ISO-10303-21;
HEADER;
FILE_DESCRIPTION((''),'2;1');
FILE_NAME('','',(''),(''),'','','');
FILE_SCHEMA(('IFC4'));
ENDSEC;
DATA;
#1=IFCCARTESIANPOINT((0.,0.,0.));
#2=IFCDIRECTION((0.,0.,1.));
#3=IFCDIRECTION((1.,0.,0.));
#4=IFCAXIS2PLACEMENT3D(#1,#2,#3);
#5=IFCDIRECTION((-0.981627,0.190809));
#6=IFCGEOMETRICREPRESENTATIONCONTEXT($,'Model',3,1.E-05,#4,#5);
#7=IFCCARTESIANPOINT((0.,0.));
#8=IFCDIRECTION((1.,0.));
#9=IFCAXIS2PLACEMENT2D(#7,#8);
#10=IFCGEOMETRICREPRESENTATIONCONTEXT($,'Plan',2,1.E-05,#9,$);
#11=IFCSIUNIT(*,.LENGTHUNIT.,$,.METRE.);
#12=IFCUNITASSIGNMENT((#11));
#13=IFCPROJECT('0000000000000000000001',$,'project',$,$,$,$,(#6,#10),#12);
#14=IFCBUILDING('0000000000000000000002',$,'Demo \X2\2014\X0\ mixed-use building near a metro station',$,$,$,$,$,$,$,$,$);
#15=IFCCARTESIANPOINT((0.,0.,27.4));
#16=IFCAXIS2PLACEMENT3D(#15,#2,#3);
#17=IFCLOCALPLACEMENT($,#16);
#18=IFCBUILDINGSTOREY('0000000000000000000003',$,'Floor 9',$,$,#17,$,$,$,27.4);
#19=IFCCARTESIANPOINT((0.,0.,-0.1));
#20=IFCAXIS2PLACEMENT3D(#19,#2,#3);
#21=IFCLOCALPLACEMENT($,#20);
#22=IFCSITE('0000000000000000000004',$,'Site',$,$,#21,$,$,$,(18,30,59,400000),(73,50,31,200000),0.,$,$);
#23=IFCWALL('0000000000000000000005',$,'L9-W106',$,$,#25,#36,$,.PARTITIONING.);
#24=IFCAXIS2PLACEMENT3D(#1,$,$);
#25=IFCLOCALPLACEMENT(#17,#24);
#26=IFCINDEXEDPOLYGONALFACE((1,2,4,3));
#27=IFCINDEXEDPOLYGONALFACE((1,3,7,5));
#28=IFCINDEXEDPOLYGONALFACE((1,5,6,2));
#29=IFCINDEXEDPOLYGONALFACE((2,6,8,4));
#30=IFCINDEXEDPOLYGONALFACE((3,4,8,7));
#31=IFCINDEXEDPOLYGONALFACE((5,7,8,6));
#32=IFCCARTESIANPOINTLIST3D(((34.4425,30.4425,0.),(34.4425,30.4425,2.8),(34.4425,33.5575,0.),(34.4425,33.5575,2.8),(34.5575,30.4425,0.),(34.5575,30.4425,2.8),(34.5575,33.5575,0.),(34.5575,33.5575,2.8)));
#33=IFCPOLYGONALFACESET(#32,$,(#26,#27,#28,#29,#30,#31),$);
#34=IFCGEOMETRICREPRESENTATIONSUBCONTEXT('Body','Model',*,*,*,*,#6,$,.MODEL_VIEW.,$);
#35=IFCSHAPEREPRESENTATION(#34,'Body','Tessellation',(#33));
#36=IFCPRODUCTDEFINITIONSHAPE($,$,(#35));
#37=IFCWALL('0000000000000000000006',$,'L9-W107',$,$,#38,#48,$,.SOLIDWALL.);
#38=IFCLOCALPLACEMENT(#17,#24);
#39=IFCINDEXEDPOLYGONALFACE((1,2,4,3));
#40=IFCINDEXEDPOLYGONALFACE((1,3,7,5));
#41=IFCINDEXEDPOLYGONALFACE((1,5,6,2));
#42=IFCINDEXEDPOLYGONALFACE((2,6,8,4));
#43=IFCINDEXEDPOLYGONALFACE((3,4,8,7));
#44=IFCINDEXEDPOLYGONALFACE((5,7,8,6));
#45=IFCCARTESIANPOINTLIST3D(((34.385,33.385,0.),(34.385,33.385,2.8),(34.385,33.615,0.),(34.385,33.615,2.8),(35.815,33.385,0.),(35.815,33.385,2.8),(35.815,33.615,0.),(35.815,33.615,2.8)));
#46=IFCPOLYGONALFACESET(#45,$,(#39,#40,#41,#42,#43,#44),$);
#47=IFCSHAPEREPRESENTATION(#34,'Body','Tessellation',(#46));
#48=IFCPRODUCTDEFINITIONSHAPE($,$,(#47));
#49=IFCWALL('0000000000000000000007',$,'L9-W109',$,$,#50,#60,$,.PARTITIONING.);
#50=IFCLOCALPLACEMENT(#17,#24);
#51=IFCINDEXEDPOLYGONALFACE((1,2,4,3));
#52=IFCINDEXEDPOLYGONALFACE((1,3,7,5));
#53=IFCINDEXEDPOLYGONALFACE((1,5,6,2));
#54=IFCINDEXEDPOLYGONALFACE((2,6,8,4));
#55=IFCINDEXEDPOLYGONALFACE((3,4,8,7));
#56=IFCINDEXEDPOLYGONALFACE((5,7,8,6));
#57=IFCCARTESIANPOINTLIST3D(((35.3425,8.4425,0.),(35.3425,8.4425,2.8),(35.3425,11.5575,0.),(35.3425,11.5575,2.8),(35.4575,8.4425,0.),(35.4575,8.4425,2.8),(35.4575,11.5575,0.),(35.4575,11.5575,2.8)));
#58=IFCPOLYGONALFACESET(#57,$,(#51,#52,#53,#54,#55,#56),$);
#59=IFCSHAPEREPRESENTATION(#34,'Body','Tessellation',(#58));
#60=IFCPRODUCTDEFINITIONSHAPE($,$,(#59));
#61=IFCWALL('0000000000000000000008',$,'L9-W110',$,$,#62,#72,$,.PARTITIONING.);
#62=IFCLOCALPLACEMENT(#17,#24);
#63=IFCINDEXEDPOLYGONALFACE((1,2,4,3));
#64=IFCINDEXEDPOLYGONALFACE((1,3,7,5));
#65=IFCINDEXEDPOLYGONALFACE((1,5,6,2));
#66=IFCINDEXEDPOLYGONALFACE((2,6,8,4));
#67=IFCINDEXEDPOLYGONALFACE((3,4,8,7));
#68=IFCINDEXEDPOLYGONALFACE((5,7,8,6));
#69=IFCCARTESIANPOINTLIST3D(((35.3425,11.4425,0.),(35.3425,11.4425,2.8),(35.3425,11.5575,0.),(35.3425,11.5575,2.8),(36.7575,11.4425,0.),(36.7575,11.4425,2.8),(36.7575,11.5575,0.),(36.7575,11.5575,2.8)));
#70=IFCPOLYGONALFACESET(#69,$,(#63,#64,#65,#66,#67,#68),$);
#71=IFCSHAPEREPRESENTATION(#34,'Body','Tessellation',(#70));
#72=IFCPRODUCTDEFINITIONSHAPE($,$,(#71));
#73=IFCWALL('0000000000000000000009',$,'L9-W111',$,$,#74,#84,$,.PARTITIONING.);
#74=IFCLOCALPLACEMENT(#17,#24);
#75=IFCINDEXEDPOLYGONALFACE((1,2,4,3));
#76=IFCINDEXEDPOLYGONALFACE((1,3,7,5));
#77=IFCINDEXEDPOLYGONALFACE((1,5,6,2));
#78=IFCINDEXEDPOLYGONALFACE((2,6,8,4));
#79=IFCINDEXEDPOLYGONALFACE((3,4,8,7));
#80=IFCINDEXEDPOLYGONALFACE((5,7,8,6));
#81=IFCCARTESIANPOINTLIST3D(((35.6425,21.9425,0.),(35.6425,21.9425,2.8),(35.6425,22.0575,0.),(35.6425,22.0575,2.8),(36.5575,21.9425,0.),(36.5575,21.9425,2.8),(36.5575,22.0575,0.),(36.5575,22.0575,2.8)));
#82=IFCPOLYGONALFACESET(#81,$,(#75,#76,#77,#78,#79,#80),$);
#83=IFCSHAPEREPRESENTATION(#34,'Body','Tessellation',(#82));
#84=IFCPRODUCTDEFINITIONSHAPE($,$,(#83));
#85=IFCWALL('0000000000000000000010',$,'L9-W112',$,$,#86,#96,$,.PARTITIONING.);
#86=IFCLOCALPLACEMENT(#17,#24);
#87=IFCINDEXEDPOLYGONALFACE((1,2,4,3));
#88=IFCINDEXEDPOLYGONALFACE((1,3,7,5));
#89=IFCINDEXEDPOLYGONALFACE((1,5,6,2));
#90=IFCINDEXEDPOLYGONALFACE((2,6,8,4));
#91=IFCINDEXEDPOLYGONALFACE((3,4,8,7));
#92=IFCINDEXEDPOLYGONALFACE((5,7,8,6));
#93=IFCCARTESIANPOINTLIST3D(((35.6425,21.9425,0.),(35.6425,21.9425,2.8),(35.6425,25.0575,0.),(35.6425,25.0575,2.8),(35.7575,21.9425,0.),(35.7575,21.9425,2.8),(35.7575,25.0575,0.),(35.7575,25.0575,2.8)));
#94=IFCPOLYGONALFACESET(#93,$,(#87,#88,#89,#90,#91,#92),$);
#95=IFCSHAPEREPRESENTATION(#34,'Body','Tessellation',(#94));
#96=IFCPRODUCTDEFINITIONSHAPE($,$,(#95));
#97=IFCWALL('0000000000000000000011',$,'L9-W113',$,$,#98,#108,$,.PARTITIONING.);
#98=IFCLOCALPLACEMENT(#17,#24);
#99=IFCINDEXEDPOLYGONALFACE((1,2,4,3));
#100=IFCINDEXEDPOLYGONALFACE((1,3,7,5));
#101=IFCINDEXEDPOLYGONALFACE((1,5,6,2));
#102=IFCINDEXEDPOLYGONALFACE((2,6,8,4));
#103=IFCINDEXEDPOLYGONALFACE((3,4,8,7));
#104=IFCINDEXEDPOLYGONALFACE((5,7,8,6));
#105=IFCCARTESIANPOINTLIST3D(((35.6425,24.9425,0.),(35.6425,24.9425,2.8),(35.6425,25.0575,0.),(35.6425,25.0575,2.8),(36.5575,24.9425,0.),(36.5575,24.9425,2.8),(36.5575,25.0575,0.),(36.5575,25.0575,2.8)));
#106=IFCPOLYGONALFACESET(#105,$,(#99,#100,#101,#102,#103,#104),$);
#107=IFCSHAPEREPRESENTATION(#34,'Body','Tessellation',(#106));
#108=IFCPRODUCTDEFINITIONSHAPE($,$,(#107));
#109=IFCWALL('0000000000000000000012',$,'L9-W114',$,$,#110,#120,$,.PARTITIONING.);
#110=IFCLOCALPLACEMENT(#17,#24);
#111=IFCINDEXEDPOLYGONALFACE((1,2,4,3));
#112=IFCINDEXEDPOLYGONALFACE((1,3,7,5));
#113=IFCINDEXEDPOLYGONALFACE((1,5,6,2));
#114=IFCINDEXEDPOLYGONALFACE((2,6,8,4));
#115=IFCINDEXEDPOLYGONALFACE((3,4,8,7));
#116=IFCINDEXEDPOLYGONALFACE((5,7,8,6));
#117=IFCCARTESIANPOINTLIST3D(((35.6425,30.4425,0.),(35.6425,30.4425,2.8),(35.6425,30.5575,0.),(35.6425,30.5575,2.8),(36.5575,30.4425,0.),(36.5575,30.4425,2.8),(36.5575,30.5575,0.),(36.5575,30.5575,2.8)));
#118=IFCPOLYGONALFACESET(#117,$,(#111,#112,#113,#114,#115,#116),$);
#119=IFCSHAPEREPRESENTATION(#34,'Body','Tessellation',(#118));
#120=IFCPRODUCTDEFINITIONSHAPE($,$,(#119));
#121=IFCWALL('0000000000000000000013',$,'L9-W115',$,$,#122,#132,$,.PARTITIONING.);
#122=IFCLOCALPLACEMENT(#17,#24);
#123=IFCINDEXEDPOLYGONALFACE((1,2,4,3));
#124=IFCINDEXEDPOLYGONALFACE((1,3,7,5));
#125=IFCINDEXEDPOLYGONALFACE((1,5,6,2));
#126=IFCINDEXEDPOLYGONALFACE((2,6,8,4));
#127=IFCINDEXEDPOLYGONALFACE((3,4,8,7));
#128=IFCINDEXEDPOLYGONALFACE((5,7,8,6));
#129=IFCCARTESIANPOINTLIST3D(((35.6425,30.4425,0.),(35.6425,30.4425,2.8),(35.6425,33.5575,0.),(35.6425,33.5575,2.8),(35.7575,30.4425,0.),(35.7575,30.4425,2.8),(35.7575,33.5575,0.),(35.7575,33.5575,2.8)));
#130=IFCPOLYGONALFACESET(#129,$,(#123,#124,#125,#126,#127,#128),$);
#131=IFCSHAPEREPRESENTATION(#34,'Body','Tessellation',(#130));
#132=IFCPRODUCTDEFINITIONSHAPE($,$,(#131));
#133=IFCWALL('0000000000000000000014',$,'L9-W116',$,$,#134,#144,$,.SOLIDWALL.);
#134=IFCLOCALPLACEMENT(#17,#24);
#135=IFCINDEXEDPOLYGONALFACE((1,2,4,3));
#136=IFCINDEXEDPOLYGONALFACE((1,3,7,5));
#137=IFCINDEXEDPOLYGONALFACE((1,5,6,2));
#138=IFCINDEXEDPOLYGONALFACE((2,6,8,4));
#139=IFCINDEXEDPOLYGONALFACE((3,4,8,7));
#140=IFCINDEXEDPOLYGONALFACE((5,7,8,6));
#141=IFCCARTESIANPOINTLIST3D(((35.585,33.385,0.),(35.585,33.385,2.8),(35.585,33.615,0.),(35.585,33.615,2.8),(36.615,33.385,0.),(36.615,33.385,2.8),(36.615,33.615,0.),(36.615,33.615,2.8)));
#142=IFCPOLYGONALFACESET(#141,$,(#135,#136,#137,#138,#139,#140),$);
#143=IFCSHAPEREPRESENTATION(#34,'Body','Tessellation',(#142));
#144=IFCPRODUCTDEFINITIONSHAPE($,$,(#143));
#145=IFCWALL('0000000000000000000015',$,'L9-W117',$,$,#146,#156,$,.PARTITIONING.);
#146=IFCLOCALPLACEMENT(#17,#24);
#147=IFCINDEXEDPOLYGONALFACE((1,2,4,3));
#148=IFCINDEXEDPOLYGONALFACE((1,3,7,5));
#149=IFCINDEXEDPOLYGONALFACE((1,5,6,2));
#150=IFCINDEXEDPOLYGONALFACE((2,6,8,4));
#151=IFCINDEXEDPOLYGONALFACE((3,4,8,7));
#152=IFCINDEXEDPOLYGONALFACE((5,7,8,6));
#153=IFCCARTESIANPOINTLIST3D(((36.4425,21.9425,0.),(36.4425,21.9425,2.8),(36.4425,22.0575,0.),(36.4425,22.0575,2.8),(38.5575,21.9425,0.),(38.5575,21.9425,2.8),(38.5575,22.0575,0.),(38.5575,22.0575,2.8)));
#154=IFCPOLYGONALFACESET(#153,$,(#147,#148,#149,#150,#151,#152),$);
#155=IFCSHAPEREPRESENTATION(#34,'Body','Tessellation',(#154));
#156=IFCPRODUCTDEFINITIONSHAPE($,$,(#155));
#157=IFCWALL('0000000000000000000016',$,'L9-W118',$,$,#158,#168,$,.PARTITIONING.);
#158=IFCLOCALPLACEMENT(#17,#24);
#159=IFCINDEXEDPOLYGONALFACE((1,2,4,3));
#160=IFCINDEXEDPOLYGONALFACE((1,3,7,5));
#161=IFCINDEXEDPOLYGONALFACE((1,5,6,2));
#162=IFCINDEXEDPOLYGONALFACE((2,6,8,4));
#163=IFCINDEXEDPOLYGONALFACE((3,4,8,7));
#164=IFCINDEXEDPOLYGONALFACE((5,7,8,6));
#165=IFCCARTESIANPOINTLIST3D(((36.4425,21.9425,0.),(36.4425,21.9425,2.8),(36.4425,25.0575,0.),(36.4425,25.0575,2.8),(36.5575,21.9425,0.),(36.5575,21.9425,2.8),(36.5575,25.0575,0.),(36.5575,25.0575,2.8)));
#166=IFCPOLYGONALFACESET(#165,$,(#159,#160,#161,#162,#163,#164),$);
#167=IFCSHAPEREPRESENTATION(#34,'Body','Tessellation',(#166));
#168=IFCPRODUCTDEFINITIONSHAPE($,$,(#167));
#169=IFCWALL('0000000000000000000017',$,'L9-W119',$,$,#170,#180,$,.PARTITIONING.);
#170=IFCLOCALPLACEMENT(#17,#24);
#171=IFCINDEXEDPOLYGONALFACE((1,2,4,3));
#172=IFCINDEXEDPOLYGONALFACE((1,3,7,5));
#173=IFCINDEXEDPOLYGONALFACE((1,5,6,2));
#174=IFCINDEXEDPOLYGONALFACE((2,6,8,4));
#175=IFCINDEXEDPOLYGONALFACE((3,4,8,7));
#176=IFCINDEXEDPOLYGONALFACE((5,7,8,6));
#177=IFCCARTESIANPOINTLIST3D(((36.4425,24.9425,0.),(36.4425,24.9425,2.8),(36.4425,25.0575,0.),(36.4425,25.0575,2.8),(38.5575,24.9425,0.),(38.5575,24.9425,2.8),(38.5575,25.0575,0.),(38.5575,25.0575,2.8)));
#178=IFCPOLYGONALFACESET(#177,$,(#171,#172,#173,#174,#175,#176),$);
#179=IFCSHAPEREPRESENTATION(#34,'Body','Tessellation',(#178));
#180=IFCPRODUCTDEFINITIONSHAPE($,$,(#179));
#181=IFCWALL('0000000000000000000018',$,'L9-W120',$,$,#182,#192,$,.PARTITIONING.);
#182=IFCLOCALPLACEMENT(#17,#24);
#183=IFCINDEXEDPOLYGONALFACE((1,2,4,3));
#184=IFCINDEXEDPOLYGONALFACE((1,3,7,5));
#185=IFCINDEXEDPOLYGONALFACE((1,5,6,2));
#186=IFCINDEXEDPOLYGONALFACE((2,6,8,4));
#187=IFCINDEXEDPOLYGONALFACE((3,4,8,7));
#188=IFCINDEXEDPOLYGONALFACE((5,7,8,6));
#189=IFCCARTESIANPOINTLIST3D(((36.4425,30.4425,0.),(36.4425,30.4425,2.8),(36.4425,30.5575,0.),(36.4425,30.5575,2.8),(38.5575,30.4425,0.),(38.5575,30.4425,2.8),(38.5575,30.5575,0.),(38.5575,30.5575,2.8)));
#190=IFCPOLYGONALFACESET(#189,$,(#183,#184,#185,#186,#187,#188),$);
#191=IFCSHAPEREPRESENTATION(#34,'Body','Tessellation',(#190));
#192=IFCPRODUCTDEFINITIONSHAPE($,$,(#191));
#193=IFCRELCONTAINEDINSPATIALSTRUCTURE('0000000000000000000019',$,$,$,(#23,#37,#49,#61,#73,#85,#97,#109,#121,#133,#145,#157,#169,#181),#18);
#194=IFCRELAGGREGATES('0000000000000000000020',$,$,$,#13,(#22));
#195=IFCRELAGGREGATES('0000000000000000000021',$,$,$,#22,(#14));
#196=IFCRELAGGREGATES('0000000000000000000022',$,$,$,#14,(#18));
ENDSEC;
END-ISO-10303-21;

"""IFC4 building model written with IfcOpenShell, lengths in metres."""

from ifc_helpers import new_model, si_unit, direction, frame, origin_with_axes, origin_2d_with_axis, place, context, subcontext, project, spatial, line, indexed_curve, outline, extrude, element, save


model = new_model("IFC4")

# Units and contexts
model_context = context("Model", 3, precision=1e-05, world=origin_with_axes(), true_north=direction((-0.981627, 0.190809)))
plan_context = context("Plan", 2, precision=1e-05, world=origin_2d_with_axis())
body_context = subcontext(model_context, "Body", "Model", "MODEL_VIEW")
ifc_project = project(units=[si_unit("LENGTHUNIT", "METRE")], contexts=[model_context, plan_context])

# Site, building, storey
site_placement = place(None, frame((0.0, 0.0, -0.1), z_axis=(0.0, 0.0, 1.0), x_axis=(1.0, 0.0, 0.0)))
site = spatial("IfcSite", under=ifc_project, at=site_placement, Name="Site", RefLatitude=(18, 30, 59, 400000), RefLongitude=(73, 50, 31, 200000), RefElevation=0.0)
building = spatial("IfcBuilding", under=site, Name="Demo — mixed-use building near a metro station")
storey_placement = place(None, frame((0.0, 0.0, 27.4), z_axis=(0.0, 0.0, 1.0), x_axis=(1.0, 0.0, 0.0)))
storey = spatial("IfcBuildingStorey", under=building, at=storey_placement, Name="Floor 9", Elevation=27.4)

# Walls
wall_1_placement = place(storey_placement, frame((0.0, 0.0, -27.4), z_axis=(0.0, 0.0, 1.0), x_axis=(1.0, 0.0, 0.0)))
element("IfcWall", 1, at=wall_1_placement, inside=storey, Name="L9-W106", PredefinedType="PARTITIONING", context=body_context, shape_type="SweptSolid", body=[
    extrude(outline(indexed_curve([(34.4425, 30.4425), (34.4425, 33.5575), (34.5575, 33.5575), (34.5575, 30.4425)], segments=[line(1, 2, 3, 4, 1)])), frame((0.0, 0.0, 27.4), z_axis=(0.0, 0.0, 1.0), x_axis=(1.0, 0.0, 0.0)), (0.0, 0.0, 1.0), 2.8),
])
wall_2_placement = place(storey_placement, frame((0.0, 0.0, -27.4), z_axis=(0.0, 0.0, 1.0), x_axis=(1.0, 0.0, 0.0)))
element("IfcWall", 2, at=wall_2_placement, inside=storey, Name="L9-W107", PredefinedType="SOLIDWALL", context=body_context, shape_type="SweptSolid", body=[
    extrude(outline(indexed_curve([(35.815, 33.385), (34.385, 33.385), (34.385, 33.615), (35.815, 33.615)], segments=[line(1, 2, 3, 4, 1)])), frame((0.0, 0.0, 27.4), z_axis=(0.0, 0.0, 1.0), x_axis=(1.0, 0.0, 0.0)), (0.0, 0.0, 1.0), 2.8),
])

# Walls
wall_3_placement = place(storey_placement, frame((0.0, 0.0, -27.4), z_axis=(0.0, 0.0, 1.0), x_axis=(1.0, 0.0, 0.0)))
element("IfcWall", 3, at=wall_3_placement, inside=storey, Name="L9-W109", PredefinedType="PARTITIONING", context=body_context, shape_type="SweptSolid", body=[
    extrude(outline(indexed_curve([(35.4575, 11.5575), (35.4575, 8.4425), (35.3425, 8.4425), (35.3425, 11.5575)], segments=[line(1, 2, 3, 4, 1)])), frame((0.0, 0.0, 27.4), z_axis=(0.0, 0.0, 1.0), x_axis=(1.0, 0.0, 0.0)), (0.0, 0.0, 1.0), 2.8),
])
wall_4_placement = place(storey_placement, frame((0.0, 0.0, -27.4), z_axis=(0.0, 0.0, 1.0), x_axis=(1.0, 0.0, 0.0)))
element("IfcWall", 4, at=wall_4_placement, inside=storey, Name="L9-W110", PredefinedType="PARTITIONING", context=body_context, shape_type="SweptSolid", body=[
    extrude(outline(indexed_curve([(35.3425, 11.5575), (36.7575, 11.5575), (36.7575, 11.4425), (35.3425, 11.4425)], segments=[line(1, 2, 3, 4, 1)])), frame((0.0, 0.0, 27.4), z_axis=(0.0, 0.0, 1.0), x_axis=(1.0, 0.0, 0.0)), (0.0, 0.0, 1.0), 2.8),
])
wall_5_placement = place(storey_placement, frame((0.0, 0.0, -27.4), z_axis=(0.0, 0.0, 1.0), x_axis=(1.0, 0.0, 0.0)))
element("IfcWall", 5, at=wall_5_placement, inside=storey, Name="L9-W111", PredefinedType="PARTITIONING", context=body_context, shape_type="SweptSolid", body=[
    extrude(outline(indexed_curve([(36.5575, 21.9425), (35.6425, 21.9425), (35.6425, 22.0575), (36.5575, 22.0575)], segments=[line(1, 2, 3, 4, 1)])), frame((0.0, 0.0, 27.4), z_axis=(0.0, 0.0, 1.0), x_axis=(1.0, 0.0, 0.0)), (0.0, 0.0, 1.0), 2.8),
])
wall_6_placement = place(storey_placement, frame((0.0, 0.0, -27.4), z_axis=(0.0, 0.0, 1.0), x_axis=(1.0, 0.0, 0.0)))
element("IfcWall", 6, at=wall_6_placement, inside=storey, Name="L9-W112", PredefinedType="PARTITIONING", context=body_context, shape_type="SweptSolid", body=[
    extrude(outline(indexed_curve([(35.7575, 25.0575), (35.7575, 21.9425), (35.6425, 21.9425), (35.6425, 25.0575)], segments=[line(1, 2, 3, 4, 1)])), frame((0.0, 0.0, 27.4), z_axis=(0.0, 0.0, 1.0), x_axis=(1.0, 0.0, 0.0)), (0.0, 0.0, 1.0), 2.8),
])
wall_7_placement = place(storey_placement, frame((0.0, 0.0, -27.4), z_axis=(0.0, 0.0, 1.0), x_axis=(1.0, 0.0, 0.0)))
element("IfcWall", 7, at=wall_7_placement, inside=storey, Name="L9-W113", PredefinedType="PARTITIONING", context=body_context, shape_type="SweptSolid", body=[
    extrude(outline(indexed_curve([(36.5575, 24.9425), (35.6425, 24.9425), (35.6425, 25.0575), (36.5575, 25.0575)], segments=[line(1, 2, 3, 4, 1)])), frame((0.0, 0.0, 27.4), z_axis=(0.0, 0.0, 1.0), x_axis=(1.0, 0.0, 0.0)), (0.0, 0.0, 1.0), 2.8),
])
wall_8_placement = place(storey_placement, frame((0.0, 0.0, -27.4), z_axis=(0.0, 0.0, 1.0), x_axis=(1.0, 0.0, 0.0)))
element("IfcWall", 8, at=wall_8_placement, inside=storey, Name="L9-W114", PredefinedType="PARTITIONING", context=body_context, shape_type="SweptSolid", body=[
    extrude(outline(indexed_curve([(36.5575, 30.4425), (35.6425, 30.4425), (35.6425, 30.5575), (36.5575, 30.5575)], segments=[line(1, 2, 3, 4, 1)])), frame((0.0, 0.0, 27.4), z_axis=(0.0, 0.0, 1.0), x_axis=(1.0, 0.0, 0.0)), (0.0, 0.0, 1.0), 2.8),
])
wall_9_placement = place(storey_placement, frame((0.0, 0.0, -27.4), z_axis=(0.0, 0.0, 1.0), x_axis=(1.0, 0.0, 0.0)))
element("IfcWall", 9, at=wall_9_placement, inside=storey, Name="L9-W115", PredefinedType="PARTITIONING", context=body_context, shape_type="SweptSolid", body=[
    extrude(outline(indexed_curve([(35.7575, 33.5575), (35.7575, 30.4425), (35.6425, 30.4425), (35.6425, 33.5575)], segments=[line(1, 2, 3, 4, 1)])), frame((0.0, 0.0, 27.4), z_axis=(0.0, 0.0, 1.0), x_axis=(1.0, 0.0, 0.0)), (0.0, 0.0, 1.0), 2.8),
])
wall_10_placement = place(storey_placement, frame((0.0, 0.0, -27.4), z_axis=(0.0, 0.0, 1.0), x_axis=(1.0, 0.0, 0.0)))
element("IfcWall", 10, at=wall_10_placement, inside=storey, Name="L9-W116", PredefinedType="SOLIDWALL", context=body_context, shape_type="SweptSolid", body=[
    extrude(outline(indexed_curve([(36.615, 33.385), (35.585, 33.385), (35.585, 33.615), (36.615, 33.615)], segments=[line(1, 2, 3, 4, 1)])), frame((0.0, 0.0, 27.4), z_axis=(0.0, 0.0, 1.0), x_axis=(1.0, 0.0, 0.0)), (0.0, 0.0, 1.0), 2.8),
])
wall_11_placement = place(storey_placement, frame((0.0, 0.0, -27.4), z_axis=(0.0, 0.0, 1.0), x_axis=(1.0, 0.0, 0.0)))
element("IfcWall", 11, at=wall_11_placement, inside=storey, Name="L9-W117", PredefinedType="PARTITIONING", context=body_context, shape_type="SweptSolid", body=[
    extrude(outline(indexed_curve([(38.5575, 21.9425), (36.4425, 21.9425), (36.4425, 22.0575), (38.5575, 22.0575)], segments=[line(1, 2, 3, 4, 1)])), frame((0.0, 0.0, 27.4), z_axis=(0.0, 0.0, 1.0), x_axis=(1.0, 0.0, 0.0)), (0.0, 0.0, 1.0), 2.8),
])
wall_12_placement = place(storey_placement, frame((0.0, 0.0, -27.4), z_axis=(0.0, 0.0, 1.0), x_axis=(1.0, 0.0, 0.0)))
element("IfcWall", 12, at=wall_12_placement, inside=storey, Name="L9-W118", PredefinedType="PARTITIONING", context=body_context, shape_type="SweptSolid", body=[
    extrude(outline(indexed_curve([(36.5575, 25.0575), (36.5575, 21.9425), (36.4425, 21.9425), (36.4425, 25.0575)], segments=[line(1, 2, 3, 4, 1)])), frame((0.0, 0.0, 27.4), z_axis=(0.0, 0.0, 1.0), x_axis=(1.0, 0.0, 0.0)), (0.0, 0.0, 1.0), 2.8),
])
wall_13_placement = place(storey_placement, frame((0.0, 0.0, -27.4), z_axis=(0.0, 0.0, 1.0), x_axis=(1.0, 0.0, 0.0)))
element("IfcWall", 13, at=wall_13_placement, inside=storey, Name="L9-W119", PredefinedType="PARTITIONING", context=body_context, shape_type="SweptSolid", body=[
    extrude(outline(indexed_curve([(38.5575, 24.9425), (36.4425, 24.9425), (36.4425, 25.0575), (38.5575, 25.0575)], segments=[line(1, 2, 3, 4, 1)])), frame((0.0, 0.0, 27.4), z_axis=(0.0, 0.0, 1.0), x_axis=(1.0, 0.0, 0.0)), (0.0, 0.0, 1.0), 2.8),
])
wall_14_placement = place(storey_placement, frame((0.0, 0.0, -27.4), z_axis=(0.0, 0.0, 1.0), x_axis=(1.0, 0.0, 0.0)))
element("IfcWall", 14, at=wall_14_placement, inside=storey, Name="L9-W120", PredefinedType="PARTITIONING", context=body_context, shape_type="SweptSolid", body=[
    extrude(outline(indexed_curve([(38.5575, 30.4425), (36.4425, 30.4425), (36.4425, 30.5575), (38.5575, 30.5575)], segments=[line(1, 2, 3, 4, 1)])), frame((0.0, 0.0, 27.4), z_axis=(0.0, 0.0, 1.0), x_axis=(1.0, 0.0, 0.0)), (0.0, 0.0, 1.0), 2.8),
])

save(model, "model.ifc")
